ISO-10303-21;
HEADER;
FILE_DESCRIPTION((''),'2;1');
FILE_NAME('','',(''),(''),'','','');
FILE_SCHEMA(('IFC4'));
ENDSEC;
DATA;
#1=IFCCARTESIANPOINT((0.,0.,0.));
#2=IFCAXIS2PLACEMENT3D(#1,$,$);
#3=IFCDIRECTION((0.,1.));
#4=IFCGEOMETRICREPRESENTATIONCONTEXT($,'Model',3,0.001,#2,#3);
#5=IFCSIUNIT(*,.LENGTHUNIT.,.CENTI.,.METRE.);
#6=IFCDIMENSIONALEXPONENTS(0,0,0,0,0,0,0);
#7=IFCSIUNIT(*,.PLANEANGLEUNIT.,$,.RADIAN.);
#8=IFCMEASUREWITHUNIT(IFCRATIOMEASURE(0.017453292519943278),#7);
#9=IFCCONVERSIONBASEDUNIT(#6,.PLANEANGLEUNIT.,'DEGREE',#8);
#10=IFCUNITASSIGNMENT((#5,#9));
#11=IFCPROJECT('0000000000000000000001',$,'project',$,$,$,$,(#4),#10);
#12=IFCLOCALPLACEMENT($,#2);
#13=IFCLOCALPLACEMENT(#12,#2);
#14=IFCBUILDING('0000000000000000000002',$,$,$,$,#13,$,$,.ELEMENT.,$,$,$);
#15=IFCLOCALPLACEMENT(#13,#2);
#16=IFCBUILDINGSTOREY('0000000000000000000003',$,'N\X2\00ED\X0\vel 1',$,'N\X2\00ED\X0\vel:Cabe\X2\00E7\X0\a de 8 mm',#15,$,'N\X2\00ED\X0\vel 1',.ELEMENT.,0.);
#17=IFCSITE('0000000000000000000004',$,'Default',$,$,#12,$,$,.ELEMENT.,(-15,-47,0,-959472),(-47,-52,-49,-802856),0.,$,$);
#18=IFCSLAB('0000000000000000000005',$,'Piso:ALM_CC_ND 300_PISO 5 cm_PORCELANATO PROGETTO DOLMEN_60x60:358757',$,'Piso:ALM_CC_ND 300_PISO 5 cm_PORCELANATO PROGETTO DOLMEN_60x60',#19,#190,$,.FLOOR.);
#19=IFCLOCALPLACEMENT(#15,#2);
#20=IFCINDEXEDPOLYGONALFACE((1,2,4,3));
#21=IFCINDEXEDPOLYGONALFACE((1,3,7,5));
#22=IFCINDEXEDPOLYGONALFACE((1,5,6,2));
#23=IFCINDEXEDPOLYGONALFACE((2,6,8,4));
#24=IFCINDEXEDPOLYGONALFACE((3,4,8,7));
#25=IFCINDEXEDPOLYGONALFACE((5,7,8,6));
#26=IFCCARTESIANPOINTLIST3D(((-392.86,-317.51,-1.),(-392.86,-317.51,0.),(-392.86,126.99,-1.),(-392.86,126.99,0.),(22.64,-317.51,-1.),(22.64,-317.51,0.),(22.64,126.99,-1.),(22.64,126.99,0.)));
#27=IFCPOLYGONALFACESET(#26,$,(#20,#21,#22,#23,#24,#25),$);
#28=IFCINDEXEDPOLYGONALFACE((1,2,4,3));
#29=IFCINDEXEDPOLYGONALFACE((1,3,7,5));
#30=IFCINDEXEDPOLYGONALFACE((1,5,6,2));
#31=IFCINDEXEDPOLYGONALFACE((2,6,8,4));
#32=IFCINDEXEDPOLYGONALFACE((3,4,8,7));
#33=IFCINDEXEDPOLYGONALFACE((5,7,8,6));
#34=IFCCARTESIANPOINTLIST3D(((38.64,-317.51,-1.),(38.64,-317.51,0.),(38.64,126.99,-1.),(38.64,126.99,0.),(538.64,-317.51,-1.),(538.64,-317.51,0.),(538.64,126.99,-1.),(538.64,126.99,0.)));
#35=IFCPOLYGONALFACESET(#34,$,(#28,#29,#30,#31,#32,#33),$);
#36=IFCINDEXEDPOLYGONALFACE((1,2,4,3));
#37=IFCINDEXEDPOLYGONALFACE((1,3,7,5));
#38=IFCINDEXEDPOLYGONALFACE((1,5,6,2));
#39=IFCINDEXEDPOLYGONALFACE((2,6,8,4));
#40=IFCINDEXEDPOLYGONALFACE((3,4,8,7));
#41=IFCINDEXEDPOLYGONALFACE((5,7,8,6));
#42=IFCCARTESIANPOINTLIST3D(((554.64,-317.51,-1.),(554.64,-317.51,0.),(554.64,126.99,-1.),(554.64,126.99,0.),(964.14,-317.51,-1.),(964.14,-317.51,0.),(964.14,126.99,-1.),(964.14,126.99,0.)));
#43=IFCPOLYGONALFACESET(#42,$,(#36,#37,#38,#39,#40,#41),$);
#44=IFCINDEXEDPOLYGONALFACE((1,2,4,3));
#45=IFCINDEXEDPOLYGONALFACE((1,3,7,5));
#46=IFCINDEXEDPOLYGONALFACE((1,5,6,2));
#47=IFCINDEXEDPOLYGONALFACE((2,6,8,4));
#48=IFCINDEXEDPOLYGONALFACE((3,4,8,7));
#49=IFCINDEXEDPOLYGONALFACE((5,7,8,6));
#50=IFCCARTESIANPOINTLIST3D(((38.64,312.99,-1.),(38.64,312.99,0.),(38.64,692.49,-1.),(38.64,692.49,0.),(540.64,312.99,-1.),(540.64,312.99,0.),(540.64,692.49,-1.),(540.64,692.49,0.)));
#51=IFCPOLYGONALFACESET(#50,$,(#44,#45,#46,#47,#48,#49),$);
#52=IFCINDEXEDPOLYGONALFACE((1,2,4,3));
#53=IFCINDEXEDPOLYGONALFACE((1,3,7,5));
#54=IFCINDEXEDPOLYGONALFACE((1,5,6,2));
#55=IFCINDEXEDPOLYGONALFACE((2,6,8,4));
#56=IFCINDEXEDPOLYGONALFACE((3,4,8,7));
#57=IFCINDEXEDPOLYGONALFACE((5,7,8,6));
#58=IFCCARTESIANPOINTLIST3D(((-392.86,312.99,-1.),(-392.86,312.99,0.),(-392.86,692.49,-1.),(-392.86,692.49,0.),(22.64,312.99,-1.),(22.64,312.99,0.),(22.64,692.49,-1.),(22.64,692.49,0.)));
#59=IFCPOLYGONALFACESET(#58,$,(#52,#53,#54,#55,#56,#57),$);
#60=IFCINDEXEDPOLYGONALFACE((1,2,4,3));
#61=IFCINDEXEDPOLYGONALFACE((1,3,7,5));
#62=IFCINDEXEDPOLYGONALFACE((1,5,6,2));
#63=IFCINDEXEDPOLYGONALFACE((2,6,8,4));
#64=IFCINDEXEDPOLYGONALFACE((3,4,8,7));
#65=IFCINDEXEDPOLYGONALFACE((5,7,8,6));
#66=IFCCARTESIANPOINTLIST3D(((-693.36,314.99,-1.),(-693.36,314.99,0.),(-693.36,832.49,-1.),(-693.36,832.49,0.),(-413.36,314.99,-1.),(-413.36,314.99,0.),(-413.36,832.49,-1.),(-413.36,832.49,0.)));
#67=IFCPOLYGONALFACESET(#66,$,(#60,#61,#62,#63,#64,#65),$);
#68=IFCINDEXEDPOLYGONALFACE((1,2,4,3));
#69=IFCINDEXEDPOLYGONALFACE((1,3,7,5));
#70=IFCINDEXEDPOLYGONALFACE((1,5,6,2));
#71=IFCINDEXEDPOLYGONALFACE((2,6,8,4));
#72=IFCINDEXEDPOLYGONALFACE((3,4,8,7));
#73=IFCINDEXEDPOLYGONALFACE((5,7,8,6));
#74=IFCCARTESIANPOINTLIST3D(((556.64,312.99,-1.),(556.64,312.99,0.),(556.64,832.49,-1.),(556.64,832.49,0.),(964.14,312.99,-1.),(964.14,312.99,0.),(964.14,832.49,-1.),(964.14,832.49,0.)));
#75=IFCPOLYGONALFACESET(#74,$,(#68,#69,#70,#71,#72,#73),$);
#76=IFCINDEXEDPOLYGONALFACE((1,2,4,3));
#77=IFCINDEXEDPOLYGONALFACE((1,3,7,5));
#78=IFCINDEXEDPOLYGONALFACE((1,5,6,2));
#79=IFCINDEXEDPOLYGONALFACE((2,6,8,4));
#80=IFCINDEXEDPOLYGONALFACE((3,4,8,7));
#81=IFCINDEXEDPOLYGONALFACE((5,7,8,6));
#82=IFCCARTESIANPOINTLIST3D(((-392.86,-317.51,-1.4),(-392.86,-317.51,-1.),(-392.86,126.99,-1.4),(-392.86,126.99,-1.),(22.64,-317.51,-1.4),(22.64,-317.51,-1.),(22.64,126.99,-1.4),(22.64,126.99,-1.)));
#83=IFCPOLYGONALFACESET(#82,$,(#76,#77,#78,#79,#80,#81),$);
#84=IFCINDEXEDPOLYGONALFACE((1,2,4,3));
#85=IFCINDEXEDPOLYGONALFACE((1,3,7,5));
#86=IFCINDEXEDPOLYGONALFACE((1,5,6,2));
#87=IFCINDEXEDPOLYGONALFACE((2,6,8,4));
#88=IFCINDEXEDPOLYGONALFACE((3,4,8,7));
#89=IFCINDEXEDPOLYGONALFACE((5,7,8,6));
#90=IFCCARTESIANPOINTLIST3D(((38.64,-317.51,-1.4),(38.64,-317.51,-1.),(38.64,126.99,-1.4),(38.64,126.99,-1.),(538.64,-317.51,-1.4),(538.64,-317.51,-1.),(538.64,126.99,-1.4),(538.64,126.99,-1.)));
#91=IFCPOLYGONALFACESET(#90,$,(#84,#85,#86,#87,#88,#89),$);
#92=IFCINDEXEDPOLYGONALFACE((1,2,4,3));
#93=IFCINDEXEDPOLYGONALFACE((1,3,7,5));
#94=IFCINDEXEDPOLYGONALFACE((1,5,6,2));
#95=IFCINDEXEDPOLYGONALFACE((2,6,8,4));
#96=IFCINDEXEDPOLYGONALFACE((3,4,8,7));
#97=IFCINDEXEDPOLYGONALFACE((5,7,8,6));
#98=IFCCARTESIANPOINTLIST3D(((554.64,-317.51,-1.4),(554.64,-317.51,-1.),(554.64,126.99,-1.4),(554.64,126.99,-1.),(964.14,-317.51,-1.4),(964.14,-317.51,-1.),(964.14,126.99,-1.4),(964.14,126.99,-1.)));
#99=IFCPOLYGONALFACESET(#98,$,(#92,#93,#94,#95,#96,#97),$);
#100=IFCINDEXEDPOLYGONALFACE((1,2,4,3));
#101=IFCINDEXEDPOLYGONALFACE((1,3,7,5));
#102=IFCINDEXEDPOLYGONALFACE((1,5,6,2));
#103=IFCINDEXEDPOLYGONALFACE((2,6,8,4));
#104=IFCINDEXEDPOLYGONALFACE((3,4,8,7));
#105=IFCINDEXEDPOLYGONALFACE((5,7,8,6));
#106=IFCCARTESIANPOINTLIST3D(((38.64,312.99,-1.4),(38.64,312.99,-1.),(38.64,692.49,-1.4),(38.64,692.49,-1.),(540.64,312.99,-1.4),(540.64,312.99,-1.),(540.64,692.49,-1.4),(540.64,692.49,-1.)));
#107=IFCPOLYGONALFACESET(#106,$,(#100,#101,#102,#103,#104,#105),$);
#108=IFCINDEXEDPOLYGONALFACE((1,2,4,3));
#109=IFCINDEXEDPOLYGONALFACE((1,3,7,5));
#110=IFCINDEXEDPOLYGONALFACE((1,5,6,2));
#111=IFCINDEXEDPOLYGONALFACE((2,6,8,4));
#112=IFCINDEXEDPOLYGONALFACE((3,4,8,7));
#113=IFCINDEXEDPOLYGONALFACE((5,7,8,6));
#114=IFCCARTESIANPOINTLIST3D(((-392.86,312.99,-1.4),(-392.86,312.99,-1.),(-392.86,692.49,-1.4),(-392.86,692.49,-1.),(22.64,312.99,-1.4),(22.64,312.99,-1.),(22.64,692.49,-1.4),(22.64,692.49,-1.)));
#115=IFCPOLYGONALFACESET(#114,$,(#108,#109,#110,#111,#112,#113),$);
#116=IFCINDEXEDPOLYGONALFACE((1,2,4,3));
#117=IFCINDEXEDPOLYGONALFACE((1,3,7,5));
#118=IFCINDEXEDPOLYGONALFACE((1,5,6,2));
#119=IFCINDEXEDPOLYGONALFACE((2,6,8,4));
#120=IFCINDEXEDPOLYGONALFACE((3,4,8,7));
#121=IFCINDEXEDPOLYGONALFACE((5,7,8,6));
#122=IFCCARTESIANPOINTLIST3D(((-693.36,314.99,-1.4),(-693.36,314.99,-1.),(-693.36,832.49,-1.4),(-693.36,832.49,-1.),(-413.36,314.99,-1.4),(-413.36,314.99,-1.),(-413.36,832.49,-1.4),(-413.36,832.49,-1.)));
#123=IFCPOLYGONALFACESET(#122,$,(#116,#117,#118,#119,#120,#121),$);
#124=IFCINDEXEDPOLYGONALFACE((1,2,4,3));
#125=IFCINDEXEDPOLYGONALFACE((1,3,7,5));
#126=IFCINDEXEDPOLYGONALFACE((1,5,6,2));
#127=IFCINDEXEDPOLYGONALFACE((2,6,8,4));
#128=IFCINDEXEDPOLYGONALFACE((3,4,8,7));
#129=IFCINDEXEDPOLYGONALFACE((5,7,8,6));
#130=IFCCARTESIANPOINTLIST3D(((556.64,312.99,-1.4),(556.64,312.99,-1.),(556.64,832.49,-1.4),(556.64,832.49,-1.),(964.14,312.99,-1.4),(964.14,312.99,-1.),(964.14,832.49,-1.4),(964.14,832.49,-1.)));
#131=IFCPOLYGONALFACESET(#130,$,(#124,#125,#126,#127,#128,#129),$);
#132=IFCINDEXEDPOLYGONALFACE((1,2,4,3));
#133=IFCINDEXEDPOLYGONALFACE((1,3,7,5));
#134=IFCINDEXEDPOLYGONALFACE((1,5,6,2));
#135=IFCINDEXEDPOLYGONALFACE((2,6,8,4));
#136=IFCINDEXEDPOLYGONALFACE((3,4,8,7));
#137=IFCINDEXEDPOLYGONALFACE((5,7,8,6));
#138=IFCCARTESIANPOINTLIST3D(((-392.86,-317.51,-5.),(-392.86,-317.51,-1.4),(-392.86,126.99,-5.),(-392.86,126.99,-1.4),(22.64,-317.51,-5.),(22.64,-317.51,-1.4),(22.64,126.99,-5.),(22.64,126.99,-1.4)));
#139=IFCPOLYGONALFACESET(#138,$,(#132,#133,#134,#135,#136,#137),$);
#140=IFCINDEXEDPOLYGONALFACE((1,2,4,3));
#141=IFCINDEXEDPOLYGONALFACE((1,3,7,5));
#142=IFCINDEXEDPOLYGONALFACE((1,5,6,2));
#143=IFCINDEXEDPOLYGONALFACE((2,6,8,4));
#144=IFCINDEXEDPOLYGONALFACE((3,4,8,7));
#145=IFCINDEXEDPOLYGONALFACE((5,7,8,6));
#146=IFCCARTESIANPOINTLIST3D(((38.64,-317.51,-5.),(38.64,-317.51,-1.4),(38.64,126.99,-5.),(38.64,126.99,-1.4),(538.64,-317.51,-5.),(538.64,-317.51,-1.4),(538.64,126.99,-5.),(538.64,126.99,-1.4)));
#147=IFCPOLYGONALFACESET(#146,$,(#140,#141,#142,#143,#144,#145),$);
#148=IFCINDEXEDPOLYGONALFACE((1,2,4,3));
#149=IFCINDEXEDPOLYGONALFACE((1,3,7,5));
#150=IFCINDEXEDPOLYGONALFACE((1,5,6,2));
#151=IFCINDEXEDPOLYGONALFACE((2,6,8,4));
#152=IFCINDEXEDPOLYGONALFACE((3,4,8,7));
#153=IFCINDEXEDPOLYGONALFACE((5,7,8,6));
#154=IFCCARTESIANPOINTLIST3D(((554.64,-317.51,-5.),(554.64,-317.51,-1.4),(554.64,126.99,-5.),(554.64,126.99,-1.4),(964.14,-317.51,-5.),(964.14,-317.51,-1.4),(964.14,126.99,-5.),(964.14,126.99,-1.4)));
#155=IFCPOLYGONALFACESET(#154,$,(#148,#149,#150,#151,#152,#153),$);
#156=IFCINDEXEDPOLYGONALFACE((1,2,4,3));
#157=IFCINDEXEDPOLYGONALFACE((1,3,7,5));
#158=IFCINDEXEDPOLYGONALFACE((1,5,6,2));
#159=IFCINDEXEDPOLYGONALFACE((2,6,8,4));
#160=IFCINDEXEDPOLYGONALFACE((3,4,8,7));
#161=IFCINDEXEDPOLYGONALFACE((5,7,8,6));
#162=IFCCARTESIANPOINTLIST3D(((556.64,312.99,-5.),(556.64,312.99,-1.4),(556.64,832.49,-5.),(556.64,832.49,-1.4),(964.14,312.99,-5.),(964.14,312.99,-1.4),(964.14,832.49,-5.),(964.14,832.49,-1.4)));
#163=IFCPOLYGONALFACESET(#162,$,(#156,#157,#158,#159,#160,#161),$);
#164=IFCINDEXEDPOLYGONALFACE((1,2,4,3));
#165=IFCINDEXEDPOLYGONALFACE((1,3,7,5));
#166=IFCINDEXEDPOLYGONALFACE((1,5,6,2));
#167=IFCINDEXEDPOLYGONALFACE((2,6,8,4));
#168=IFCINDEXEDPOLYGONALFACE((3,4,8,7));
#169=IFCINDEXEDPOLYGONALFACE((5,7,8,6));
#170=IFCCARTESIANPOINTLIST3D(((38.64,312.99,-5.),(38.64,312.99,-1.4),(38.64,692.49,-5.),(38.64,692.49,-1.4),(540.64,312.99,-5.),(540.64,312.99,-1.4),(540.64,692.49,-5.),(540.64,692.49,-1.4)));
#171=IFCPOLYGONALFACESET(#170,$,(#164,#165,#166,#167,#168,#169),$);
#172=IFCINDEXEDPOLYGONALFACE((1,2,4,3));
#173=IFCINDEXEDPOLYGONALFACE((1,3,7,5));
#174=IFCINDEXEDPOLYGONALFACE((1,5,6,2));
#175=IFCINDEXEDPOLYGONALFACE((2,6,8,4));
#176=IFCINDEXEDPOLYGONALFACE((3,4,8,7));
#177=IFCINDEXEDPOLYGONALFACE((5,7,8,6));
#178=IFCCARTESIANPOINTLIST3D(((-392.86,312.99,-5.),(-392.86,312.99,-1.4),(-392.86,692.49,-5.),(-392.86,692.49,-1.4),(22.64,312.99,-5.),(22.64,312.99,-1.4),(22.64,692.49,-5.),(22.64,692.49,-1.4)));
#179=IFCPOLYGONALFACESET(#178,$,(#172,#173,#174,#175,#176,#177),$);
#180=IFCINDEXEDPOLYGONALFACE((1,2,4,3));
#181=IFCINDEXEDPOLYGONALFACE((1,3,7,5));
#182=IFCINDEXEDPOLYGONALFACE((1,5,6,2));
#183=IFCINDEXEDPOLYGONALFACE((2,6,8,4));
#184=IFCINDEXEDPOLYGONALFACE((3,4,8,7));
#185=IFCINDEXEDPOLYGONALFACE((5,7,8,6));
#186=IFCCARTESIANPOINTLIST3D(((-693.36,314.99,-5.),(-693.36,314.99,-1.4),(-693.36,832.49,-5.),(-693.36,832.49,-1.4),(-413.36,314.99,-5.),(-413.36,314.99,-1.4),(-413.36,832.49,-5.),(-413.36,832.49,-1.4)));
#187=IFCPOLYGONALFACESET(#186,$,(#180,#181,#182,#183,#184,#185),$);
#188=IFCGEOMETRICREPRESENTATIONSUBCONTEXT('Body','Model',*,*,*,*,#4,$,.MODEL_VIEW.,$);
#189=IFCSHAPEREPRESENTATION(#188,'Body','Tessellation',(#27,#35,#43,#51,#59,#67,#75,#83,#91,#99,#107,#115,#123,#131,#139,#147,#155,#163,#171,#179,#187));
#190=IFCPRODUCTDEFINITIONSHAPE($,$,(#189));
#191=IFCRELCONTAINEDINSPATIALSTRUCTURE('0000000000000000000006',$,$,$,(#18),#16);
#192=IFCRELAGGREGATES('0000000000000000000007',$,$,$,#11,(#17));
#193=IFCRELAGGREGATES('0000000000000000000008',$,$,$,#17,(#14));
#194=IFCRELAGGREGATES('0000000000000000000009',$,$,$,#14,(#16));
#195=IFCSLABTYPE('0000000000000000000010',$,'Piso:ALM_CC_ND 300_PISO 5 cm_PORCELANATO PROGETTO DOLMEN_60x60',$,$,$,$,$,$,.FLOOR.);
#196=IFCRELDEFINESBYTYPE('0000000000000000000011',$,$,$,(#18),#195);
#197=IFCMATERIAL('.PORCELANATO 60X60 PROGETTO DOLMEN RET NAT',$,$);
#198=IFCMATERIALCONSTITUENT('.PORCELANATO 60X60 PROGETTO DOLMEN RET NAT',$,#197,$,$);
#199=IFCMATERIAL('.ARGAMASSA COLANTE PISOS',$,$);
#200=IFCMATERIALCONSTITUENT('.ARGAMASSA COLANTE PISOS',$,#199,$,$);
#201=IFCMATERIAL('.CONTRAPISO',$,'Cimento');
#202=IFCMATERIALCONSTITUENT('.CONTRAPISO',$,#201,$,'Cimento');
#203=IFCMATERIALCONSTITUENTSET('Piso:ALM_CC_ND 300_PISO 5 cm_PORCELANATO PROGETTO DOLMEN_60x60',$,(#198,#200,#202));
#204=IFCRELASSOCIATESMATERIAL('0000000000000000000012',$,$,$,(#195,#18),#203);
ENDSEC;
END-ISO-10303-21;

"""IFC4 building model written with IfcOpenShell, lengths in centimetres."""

from ifc_helpers import new_model, entity, si_unit, converted_unit, direction, frame, origin, place, context, subcontext, project, spatial, indexed_curve, outline, extrude, material, constituent, constituent_set, type_object, element, save


model = new_model("IFC4")

# Units and contexts
model_context = context("Model", 3, precision=0.001, world=origin(), true_north=direction((0.0, 1.0)))
body_context = subcontext(model_context, "Body", "Model", "MODEL_VIEW")
ifc_project = project(units=[si_unit("LENGTHUNIT", "METRE", prefix="CENTI"), converted_unit("PLANEANGLEUNIT", "DEGREE", entity("IfcRatioMeasure", 0.017453292519943278), si_unit("PLANEANGLEUNIT", "RADIAN"), dimensions=[0, 0, 0, 0, 0, 0, 0])], contexts=[model_context])

# Site, building, storey
site_placement = place(None, origin())
site = spatial("IfcSite", under=ifc_project, at=site_placement, Name="Default", CompositionType="ELEMENT", RefLatitude=(-15, -47, 0, -959472), RefLongitude=(-47, -52, -49, -802856), RefElevation=0.0)
building_placement = place(site_placement, origin())
building = spatial("IfcBuilding", under=site, at=building_placement, CompositionType="ELEMENT")
storey_placement = place(building_placement, origin())
storey = spatial("IfcBuildingStorey", under=building, at=storey_placement, Name="Nível 1", ObjectType="Nível:Cabeça de 8 mm", LongName="Nível 1", CompositionType="ELEMENT", Elevation=0.0)

# Slab
ifc_material_1 = material(Name=".ARGAMASSA COLANTE PISOS")
ifc_material_2 = material(Name=".CONTRAPISO", Category="Cimento")
ifc_material_3 = material(Name=".PORCELANATO 60X60 PROGETTO DOLMEN RET NAT")
ifc_constituent_1 = constituent(ifc_material_3, Name=".PORCELANATO 60X60 PROGETTO DOLMEN RET NAT")
ifc_constituent_2 = constituent(ifc_material_1, Name=".ARGAMASSA COLANTE PISOS")
ifc_constituent_3 = constituent(ifc_material_2, Name=".CONTRAPISO", Category="Cimento")
ifc_constituent_set_1 = constituent_set(constituents=[ifc_constituent_1, ifc_constituent_2, ifc_constituent_3], Name="Piso:ALM_CC_ND 300_PISO 5 cm_PORCELANATO PROGETTO DOLMEN_60x60")
slab_type_1 = type_object("IfcSlabType", Name="Piso:ALM_CC_ND 300_PISO 5 cm_PORCELANATO PROGETTO DOLMEN_60x60", PredefinedType="FLOOR", material=ifc_constituent_set_1)
slab_1_placement = place(storey_placement, origin())
element("IfcSlab", 1, at=slab_1_placement, inside=storey, type_object=slab_type_1, material=ifc_constituent_set_1, Name="Piso:ALM_CC_ND 300_PISO 5 cm_PORCELANATO PROGETTO DOLMEN_60x60:358757", ObjectType="Piso:ALM_CC_ND 300_PISO 5 cm_PORCELANATO PROGETTO DOLMEN_60x60", PredefinedType="FLOOR", context=body_context, shape_type="SweptSolid", body=[
    extrude(outline(indexed_curve([(-222.25, -207.75), (222.25, -207.75), (222.25, 207.75), (-222.25, 207.75), (-222.25, -207.75)], self_intersect=False)), frame((-185.11, -95.26, -1.0), z_axis=(0.0, 0.0, 1.0), x_axis=(0.0, -1.0, 0.0)), (0.0, 0.0, 1.0), 1.0),
    extrude(outline(indexed_curve([(-222.25, -250.0), (222.25, -250.0), (222.25, 250.0), (-222.25, 250.0), (-222.25, -250.0)], self_intersect=False)), frame((288.64, -95.26, -1.0), z_axis=(0.0, 0.0, 1.0), x_axis=(0.0, -1.0, 0.0)), (0.0, 0.0, 1.0), 1.0),
    extrude(outline(indexed_curve([(-222.25, -204.75), (222.25, -204.75), (222.25, 204.75), (-222.25, 204.75), (-222.25, -204.75)], self_intersect=False)), frame((759.39, -95.26, -1.0), z_axis=(0.0, 0.0, 1.0), x_axis=(0.0, -1.0, 0.0)), (0.0, 0.0, 1.0), 1.0),
    extrude(outline(indexed_curve([(-189.75, -251.0), (189.75, -251.0), (189.75, 251.0), (-189.75, 251.0), (-189.75, -251.0)], self_intersect=False)), frame((289.64, 502.74, -1.0), z_axis=(0.0, 0.0, 1.0), x_axis=(0.0, -1.0, 0.0)), (0.0, 0.0, 1.0), 1.0),
    extrude(outline(indexed_curve([(-189.75, -207.75), (189.75, -207.75), (189.75, 207.75), (-189.75, 207.75), (-189.75, -207.75)], self_intersect=False)), frame((-185.11, 502.74, -1.0), z_axis=(0.0, 0.0, 1.0), x_axis=(0.0, -1.0, 0.0)), (0.0, 0.0, 1.0), 1.0),
    extrude(outline(indexed_curve([(-258.75, -140.0), (258.75, -140.0), (258.75, 140.0), (-258.75, 140.0), (-258.75, -140.0)], self_intersect=False)), frame((-553.36, 573.74, -1.0), z_axis=(0.0, 0.0, 1.0), x_axis=(0.0, -1.0, 0.0)), (0.0, 0.0, 1.0), 1.0),
    extrude(outline(indexed_curve([(-259.75, -203.75), (259.75, -203.75), (259.75, 203.75), (-259.75, 203.75), (-259.75, -203.75)], self_intersect=False)), frame((760.39, 572.74, -1.0), z_axis=(0.0, 0.0, 1.0), x_axis=(0.0, -1.0, 0.0)), (0.0, 0.0, 1.0), 1.0),
    extrude(outline(indexed_curve([(-222.25, -207.75), (222.25, -207.75), (222.25, 207.75), (-222.25, 207.75), (-222.25, -207.75)], self_intersect=False)), frame((-185.11, -95.26, -1.4), z_axis=(0.0, 0.0, 1.0), x_axis=(0.0, -1.0, 0.0)), (0.0, 0.0, 1.0), 0.4),
    extrude(outline(indexed_curve([(-222.25, -250.0), (222.25, -250.0), (222.25, 250.0), (-222.25, 250.0), (-222.25, -250.0)], self_intersect=False)), frame((288.64, -95.26, -1.4), z_axis=(0.0, 0.0, 1.0), x_axis=(0.0, -1.0, 0.0)), (0.0, 0.0, 1.0), 0.4),
    extrude(outline(indexed_curve([(-222.25, -204.75), (222.25, -204.75), (222.25, 204.75), (-222.25, 204.75), (-222.25, -204.75)], self_intersect=False)), frame((759.39, -95.26, -1.4), z_axis=(0.0, 0.0, 1.0), x_axis=(0.0, -1.0, 0.0)), (0.0, 0.0, 1.0), 0.4),
    extrude(outline(indexed_curve([(-189.75, -251.0), (189.75, -251.0), (189.75, 251.0), (-189.75, 251.0), (-189.75, -251.0)], self_intersect=False)), frame((289.64, 502.74, -1.4), z_axis=(0.0, 0.0, 1.0), x_axis=(0.0, -1.0, 0.0)), (0.0, 0.0, 1.0), 0.4),
    extrude(outline(indexed_curve([(-189.75, -207.75), (189.75, -207.75), (189.75, 207.75), (-189.75, 207.75), (-189.75, -207.75)], self_intersect=False)), frame((-185.11, 502.74, -1.4), z_axis=(0.0, 0.0, 1.0), x_axis=(0.0, -1.0, 0.0)), (0.0, 0.0, 1.0), 0.4),
    extrude(outline(indexed_curve([(-258.75, -140.0), (258.75, -140.0), (258.75, 140.0), (-258.75, 140.0), (-258.75, -140.0)], self_intersect=False)), frame((-553.36, 573.74, -1.4), z_axis=(0.0, 0.0, 1.0), x_axis=(0.0, -1.0, 0.0)), (0.0, 0.0, 1.0), 0.4),
    extrude(outline(indexed_curve([(-259.75, -203.75), (259.75, -203.75), (259.75, 203.75), (-259.75, 203.75), (-259.75, -203.75)], self_intersect=False)), frame((760.39, 572.74, -1.4), z_axis=(0.0, 0.0, 1.0), x_axis=(0.0, -1.0, 0.0)), (0.0, 0.0, 1.0), 0.4),
    extrude(outline(indexed_curve([(-222.25, -207.75), (222.25, -207.75), (222.25, 207.75), (-222.25, 207.75), (-222.25, -207.75)], self_intersect=False)), frame((-185.11, -95.26, -5.0), z_axis=(0.0, 0.0, 1.0), x_axis=(0.0, -1.0, 0.0)), (0.0, 0.0, 1.0), 3.6),
    extrude(outline(indexed_curve([(-222.25, -250.0), (222.25, -250.0), (222.25, 250.0), (-222.25, 250.0), (-222.25, -250.0)], self_intersect=False)), frame((288.64, -95.26, -5.0), z_axis=(0.0, 0.0, 1.0), x_axis=(0.0, -1.0, 0.0)), (0.0, 0.0, 1.0), 3.6),
    extrude(outline(indexed_curve([(-222.25, -204.75), (222.25, -204.75), (222.25, 204.75), (-222.25, 204.75), (-222.25, -204.75)], self_intersect=False)), frame((759.39, -95.26, -5.0), z_axis=(0.0, 0.0, 1.0), x_axis=(0.0, -1.0, 0.0)), (0.0, 0.0, 1.0), 3.6),
    extrude(outline(indexed_curve([(-259.75, -203.75), (259.75, -203.75), (259.75, 203.75), (-259.75, 203.75), (-259.75, -203.75)], self_intersect=False)), frame((760.39, 572.74, -5.0), z_axis=(0.0, 0.0, 1.0), x_axis=(0.0, -1.0, 0.0)), (0.0, 0.0, 1.0), 3.6),
    extrude(outline(indexed_curve([(-189.75, -251.0), (189.75, -251.0), (189.75, 251.0), (-189.75, 251.0), (-189.75, -251.0)], self_intersect=False)), frame((289.64, 502.74, -5.0), z_axis=(0.0, 0.0, 1.0), x_axis=(0.0, -1.0, 0.0)), (0.0, 0.0, 1.0), 3.6),
    extrude(outline(indexed_curve([(-189.75, -207.75), (189.75, -207.75), (189.75, 207.75), (-189.75, 207.75), (-189.75, -207.75)], self_intersect=False)), frame((-185.11, 502.74, -5.0), z_axis=(0.0, 0.0, 1.0), x_axis=(0.0, -1.0, 0.0)), (0.0, 0.0, 1.0), 3.6),
    extrude(outline(indexed_curve([(-258.75, -140.0), (258.75, -140.0), (258.75, 140.0), (-258.75, 140.0), (-258.75, -140.0)], self_intersect=False)), frame((-553.36, 573.74, -5.0), z_axis=(0.0, 0.0, 1.0), x_axis=(0.0, -1.0, 0.0)), (0.0, 0.0, 1.0), 3.6),
])

save(model, "model.ifc")
